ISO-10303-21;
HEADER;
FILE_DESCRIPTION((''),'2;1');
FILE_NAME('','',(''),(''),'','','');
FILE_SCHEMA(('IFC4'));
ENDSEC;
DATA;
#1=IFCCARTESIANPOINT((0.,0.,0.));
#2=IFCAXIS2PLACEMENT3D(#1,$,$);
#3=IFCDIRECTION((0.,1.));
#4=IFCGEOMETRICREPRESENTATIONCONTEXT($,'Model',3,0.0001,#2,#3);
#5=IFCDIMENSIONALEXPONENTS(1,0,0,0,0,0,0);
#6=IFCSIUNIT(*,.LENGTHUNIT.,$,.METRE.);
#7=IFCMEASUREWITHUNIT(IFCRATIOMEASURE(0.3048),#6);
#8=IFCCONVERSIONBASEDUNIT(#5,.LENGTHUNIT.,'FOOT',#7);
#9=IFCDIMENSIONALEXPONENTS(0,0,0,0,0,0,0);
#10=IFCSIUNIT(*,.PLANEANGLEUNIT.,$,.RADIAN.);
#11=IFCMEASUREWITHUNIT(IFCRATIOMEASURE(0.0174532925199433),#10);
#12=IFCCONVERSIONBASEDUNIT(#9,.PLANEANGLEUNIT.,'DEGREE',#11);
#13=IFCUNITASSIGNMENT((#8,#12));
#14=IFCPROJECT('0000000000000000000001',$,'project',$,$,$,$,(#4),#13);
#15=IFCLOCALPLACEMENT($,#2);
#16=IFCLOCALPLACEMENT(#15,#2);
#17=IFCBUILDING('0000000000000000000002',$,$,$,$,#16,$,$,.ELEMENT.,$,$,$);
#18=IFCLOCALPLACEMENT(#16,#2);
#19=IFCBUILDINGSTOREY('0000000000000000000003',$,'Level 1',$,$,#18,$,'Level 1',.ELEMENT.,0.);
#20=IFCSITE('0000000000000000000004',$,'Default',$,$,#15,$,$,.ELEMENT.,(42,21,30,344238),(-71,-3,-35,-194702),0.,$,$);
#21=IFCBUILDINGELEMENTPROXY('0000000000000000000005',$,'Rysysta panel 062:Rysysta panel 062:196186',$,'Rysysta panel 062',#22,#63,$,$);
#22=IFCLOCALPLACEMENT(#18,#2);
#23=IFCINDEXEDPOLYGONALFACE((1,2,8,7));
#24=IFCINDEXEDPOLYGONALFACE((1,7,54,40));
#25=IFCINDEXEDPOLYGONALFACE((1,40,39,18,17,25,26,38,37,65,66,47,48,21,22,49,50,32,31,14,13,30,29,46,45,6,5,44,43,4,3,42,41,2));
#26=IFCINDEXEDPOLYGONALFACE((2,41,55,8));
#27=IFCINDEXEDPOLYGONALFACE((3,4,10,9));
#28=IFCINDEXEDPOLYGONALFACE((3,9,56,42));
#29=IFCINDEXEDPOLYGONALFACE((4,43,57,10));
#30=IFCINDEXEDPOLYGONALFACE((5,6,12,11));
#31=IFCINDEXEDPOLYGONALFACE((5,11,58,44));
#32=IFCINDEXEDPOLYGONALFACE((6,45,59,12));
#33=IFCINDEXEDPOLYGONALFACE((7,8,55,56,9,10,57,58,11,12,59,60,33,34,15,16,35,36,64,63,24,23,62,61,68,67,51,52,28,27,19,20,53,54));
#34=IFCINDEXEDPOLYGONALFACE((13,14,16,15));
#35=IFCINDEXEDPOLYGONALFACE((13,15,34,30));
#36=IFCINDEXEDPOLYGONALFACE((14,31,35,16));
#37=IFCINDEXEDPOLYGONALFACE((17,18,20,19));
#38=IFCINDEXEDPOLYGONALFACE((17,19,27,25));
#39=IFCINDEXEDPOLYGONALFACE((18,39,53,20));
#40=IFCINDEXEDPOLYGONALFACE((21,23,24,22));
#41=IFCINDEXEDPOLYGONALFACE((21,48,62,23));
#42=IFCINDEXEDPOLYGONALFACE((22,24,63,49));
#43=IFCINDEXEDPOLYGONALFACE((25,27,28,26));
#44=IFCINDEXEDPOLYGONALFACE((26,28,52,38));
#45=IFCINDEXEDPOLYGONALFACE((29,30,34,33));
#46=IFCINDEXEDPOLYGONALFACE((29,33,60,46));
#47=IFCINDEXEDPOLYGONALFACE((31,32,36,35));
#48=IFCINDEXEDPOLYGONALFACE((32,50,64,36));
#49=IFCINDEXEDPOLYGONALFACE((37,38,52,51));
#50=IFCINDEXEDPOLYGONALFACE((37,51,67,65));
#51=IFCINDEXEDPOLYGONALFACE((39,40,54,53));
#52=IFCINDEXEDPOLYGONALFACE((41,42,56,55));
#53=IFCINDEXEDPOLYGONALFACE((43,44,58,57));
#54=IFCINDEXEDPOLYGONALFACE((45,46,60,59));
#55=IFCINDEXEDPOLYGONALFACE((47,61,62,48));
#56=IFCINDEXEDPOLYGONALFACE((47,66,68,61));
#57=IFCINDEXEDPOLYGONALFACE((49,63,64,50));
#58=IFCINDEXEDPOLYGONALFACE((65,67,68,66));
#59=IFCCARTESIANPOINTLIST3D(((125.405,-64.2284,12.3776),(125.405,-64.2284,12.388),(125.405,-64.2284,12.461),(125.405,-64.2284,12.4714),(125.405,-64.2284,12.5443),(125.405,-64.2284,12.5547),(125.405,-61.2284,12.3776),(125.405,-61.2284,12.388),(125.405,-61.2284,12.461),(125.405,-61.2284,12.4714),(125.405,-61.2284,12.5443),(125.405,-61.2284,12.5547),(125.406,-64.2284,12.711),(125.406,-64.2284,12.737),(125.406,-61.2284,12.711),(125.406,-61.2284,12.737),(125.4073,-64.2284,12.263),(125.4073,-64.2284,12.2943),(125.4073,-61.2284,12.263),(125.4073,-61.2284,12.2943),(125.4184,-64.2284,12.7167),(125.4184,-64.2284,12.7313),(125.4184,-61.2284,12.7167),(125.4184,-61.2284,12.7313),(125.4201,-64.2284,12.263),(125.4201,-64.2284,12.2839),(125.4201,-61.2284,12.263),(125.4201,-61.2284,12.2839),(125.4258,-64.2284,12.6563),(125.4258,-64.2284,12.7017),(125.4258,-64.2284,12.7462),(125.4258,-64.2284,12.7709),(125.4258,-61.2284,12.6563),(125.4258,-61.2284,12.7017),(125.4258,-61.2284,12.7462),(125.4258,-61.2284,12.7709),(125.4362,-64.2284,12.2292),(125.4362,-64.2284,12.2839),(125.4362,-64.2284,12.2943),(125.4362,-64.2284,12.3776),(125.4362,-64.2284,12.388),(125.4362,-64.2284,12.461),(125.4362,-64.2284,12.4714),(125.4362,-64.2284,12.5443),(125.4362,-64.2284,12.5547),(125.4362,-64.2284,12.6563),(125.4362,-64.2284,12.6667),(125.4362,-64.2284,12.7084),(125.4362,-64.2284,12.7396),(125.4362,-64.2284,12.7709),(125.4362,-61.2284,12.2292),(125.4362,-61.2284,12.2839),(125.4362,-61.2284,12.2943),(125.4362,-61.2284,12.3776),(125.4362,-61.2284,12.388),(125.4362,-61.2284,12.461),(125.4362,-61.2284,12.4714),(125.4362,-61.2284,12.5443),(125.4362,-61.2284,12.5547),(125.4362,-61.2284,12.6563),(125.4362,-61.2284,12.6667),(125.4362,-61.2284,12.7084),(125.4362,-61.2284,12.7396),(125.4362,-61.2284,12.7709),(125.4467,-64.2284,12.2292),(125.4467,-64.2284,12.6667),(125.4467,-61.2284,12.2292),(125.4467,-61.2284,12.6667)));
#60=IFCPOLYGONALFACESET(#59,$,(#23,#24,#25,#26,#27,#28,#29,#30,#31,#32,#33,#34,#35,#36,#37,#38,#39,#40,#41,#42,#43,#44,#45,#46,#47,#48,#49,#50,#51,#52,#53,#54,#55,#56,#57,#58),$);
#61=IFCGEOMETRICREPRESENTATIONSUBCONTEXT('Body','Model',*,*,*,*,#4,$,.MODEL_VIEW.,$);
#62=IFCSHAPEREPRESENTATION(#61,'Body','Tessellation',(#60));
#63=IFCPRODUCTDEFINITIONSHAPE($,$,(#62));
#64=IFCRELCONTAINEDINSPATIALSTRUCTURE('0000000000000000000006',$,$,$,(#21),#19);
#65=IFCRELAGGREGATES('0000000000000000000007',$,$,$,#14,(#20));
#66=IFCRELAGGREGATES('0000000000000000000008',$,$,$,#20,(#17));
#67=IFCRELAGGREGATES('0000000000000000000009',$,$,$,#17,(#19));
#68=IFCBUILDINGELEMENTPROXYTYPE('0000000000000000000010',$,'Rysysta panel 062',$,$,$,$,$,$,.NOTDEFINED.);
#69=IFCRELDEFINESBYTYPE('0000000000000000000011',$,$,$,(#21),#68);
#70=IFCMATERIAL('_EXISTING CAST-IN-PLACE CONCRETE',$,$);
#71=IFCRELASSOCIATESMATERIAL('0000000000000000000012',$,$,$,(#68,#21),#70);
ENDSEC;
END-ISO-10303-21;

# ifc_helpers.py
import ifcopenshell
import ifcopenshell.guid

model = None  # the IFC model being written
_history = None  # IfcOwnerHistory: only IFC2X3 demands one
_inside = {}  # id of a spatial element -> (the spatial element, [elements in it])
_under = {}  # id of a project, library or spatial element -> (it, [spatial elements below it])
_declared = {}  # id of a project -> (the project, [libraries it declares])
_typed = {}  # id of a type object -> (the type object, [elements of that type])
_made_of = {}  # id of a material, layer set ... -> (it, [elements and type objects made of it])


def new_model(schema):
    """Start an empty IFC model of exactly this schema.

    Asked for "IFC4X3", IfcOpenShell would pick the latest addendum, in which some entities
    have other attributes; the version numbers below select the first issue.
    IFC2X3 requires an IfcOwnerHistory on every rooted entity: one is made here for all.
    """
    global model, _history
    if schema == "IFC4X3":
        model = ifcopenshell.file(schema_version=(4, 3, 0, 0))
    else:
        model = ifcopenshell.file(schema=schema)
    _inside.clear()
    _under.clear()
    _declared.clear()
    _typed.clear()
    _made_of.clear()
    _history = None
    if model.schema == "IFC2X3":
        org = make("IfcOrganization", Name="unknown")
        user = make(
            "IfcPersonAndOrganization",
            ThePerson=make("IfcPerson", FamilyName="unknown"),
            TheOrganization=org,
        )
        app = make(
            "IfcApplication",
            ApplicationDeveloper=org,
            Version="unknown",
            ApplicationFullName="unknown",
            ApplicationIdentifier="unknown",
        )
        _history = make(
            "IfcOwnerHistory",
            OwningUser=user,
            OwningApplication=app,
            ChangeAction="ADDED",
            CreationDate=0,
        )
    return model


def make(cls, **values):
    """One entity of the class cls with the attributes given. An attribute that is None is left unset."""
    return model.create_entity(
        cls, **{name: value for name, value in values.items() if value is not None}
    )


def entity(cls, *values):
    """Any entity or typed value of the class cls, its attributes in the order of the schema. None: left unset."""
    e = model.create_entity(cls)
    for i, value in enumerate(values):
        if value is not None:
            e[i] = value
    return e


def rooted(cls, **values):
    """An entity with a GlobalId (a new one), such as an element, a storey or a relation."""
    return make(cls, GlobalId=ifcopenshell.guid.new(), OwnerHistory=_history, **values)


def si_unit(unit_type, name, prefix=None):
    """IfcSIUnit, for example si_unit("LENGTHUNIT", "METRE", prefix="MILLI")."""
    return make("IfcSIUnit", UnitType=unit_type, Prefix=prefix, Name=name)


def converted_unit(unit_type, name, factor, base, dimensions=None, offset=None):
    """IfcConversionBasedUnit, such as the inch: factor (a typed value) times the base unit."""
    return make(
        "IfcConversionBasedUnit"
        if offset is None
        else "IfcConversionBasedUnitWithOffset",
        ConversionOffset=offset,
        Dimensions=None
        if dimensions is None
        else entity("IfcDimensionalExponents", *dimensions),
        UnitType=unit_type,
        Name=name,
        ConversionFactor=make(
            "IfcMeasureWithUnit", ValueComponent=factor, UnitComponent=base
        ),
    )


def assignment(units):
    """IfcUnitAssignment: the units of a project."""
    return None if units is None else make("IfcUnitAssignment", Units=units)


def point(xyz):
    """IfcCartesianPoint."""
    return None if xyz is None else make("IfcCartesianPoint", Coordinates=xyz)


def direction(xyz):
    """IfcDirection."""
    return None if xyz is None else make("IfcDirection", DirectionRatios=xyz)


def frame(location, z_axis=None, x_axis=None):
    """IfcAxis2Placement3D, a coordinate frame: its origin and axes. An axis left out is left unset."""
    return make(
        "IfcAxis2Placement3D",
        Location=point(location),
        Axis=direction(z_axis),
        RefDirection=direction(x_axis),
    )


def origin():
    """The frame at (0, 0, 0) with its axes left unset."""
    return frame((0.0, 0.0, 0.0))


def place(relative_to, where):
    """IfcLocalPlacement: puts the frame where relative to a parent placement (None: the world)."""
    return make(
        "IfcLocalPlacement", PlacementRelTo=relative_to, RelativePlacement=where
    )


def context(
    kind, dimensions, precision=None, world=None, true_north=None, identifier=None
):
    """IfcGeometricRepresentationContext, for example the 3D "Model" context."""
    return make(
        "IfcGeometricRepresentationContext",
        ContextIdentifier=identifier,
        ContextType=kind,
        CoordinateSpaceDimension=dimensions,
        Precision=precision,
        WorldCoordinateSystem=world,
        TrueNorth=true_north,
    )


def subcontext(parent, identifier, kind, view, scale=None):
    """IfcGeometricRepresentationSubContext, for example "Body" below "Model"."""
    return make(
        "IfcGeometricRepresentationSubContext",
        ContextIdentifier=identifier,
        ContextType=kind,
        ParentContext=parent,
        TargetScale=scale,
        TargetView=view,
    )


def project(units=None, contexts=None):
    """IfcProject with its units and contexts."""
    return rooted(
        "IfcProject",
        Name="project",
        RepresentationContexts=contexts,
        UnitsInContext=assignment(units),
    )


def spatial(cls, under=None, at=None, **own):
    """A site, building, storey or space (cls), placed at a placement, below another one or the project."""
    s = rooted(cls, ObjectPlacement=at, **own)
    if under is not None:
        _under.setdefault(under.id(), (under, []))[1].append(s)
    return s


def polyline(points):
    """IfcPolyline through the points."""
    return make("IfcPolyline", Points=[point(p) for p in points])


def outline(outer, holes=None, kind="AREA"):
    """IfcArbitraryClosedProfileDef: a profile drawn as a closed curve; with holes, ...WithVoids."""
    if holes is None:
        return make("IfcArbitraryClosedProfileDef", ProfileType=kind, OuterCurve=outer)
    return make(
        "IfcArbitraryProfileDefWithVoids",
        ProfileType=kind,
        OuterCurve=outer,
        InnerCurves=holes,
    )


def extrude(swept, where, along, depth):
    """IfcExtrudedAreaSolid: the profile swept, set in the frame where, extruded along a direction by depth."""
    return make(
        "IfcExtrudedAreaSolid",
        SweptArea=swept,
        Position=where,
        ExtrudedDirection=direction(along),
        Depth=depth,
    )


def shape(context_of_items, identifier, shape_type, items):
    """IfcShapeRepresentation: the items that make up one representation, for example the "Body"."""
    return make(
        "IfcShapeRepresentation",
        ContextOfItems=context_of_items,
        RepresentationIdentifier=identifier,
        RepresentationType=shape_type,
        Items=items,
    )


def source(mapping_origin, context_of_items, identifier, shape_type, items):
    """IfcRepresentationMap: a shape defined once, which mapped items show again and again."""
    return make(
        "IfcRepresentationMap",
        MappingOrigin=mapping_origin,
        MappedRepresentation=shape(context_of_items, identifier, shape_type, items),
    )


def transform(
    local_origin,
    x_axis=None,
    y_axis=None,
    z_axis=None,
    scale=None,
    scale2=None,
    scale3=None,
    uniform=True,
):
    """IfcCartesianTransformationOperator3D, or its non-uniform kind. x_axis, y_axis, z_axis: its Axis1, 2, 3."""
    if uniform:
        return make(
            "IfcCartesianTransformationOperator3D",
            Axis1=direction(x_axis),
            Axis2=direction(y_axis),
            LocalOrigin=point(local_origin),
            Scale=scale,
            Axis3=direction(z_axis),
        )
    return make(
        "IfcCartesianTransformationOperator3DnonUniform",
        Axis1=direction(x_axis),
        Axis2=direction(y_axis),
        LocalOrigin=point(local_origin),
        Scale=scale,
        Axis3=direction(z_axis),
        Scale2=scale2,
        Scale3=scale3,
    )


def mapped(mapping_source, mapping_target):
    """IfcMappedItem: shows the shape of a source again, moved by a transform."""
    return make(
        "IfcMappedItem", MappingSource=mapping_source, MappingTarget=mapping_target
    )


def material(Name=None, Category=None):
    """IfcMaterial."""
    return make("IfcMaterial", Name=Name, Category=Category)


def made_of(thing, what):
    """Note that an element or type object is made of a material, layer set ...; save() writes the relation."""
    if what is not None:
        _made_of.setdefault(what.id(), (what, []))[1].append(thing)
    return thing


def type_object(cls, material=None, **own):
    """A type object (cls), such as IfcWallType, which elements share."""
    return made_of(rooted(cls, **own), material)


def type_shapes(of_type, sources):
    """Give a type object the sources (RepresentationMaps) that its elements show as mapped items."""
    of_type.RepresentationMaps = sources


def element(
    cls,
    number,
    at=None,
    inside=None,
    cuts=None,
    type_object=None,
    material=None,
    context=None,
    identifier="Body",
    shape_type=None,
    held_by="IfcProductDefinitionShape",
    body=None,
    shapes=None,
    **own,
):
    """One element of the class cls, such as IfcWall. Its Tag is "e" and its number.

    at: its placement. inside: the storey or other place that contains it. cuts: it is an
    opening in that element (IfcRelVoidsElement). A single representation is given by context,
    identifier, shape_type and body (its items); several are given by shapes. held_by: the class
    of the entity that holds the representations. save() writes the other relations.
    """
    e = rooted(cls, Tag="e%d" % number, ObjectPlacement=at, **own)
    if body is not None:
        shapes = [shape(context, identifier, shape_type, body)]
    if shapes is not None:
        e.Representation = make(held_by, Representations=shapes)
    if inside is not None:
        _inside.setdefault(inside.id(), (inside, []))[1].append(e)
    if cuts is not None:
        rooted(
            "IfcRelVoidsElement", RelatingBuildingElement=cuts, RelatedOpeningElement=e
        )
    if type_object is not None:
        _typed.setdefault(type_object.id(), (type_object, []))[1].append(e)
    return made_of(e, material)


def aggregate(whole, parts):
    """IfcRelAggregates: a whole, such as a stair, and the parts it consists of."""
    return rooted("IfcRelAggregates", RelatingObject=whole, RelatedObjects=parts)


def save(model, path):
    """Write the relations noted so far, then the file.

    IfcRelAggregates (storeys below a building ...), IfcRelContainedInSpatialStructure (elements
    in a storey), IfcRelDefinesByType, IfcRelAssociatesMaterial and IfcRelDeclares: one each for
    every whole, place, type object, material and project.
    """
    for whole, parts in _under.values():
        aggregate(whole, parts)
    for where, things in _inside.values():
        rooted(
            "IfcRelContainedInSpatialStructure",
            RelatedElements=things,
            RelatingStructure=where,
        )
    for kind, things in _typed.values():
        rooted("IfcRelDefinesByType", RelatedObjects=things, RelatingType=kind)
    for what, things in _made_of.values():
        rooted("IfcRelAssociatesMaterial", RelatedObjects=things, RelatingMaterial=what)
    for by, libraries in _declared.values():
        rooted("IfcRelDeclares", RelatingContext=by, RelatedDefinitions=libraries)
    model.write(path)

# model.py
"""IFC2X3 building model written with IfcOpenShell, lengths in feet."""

from ifc_helpers import new_model, entity, si_unit, converted_unit, direction, frame, origin, place, context, subcontext, project, spatial, polyline, outline, extrude, source, transform, mapped, material, type_object, type_shapes, element, save


model = new_model("IFC2X3")

# Units and contexts
model_context = context("Model", 3, precision=0.0001, world=origin(), true_north=direction((0.0, 1.0)))
body_context = subcontext(model_context, "Body", "Model", "MODEL_VIEW")
ifc_project = project(units=[converted_unit("LENGTHUNIT", "FOOT", entity("IfcRatioMeasure", 0.3048), si_unit("LENGTHUNIT", "METRE"), dimensions=[1, 0, 0, 0, 0, 0, 0]), converted_unit("PLANEANGLEUNIT", "DEGREE", entity("IfcRatioMeasure", 0.0174532925199433), si_unit("PLANEANGLEUNIT", "RADIAN"), dimensions=[0, 0, 0, 0, 0, 0, 0])], contexts=[model_context])

# Site, building, storey
site_placement = place(None, origin())
site = spatial("IfcSite", under=ifc_project, at=site_placement, Name="Default", CompositionType="ELEMENT", RefLatitude=(42, 21, 30, 344238), RefLongitude=(-71, -3, -35, -194702), RefElevation=0.0)
building_placement = place(site_placement, origin())
building = spatial("IfcBuilding", under=site, at=building_placement, CompositionType="ELEMENT")
storey_placement = place(building_placement, origin())
storey = spatial("IfcBuildingStorey", under=building, at=storey_placement, Name="Level 1", LongName="Level 1", CompositionType="ELEMENT", Elevation=0.0)

# Building element proxy
ifc_material_1 = material(Name="_EXISTING CAST-IN-PLACE CONCRETE")
building_element_proxy_type_1 = type_object("IfcBuildingElementProxyType", Name="Rysysta panel 062", PredefinedType="NOTDEFINED", material=ifc_material_1)
shared_shape_1 = source(origin(), body_context, "Body", "SweptSolid", [
    extrude(outline(polyline([(-0.1457, -0.022), (0.2918, -0.022), (0.2918, -0.0116), (0.2371, -0.0116), (0.2371, 0.0045), (0.258, 0.0045), (0.258, 0.0173), (0.2267, 0.0173), (0.2267, -0.0116), (0.1434, -0.0116), (0.1434, 0.0196), (0.133, 0.0196), (0.133, -0.0116), (0.06, -0.0116), (0.06, 0.0196), (0.0496, 0.0196), (0.0496, -0.0116), (-0.0233, -0.0116), (-0.0233, 0.0196), (-0.0337, 0.0196), (-0.0337, -0.0116), (-0.1353, -0.0116), (-0.1353, -0.0012), (-0.1807, -0.0012), (-0.1899, 0.0186), (-0.216, 0.0186), (-0.2252, -0.0012), (-0.2498, -0.0012), (-0.2498, -0.0116), (-0.2186, -0.0116), (-0.2103, 0.0062), (-0.1956, 0.0062), (-0.1873, -0.0116), (-0.1457, -0.0116), (-0.1457, -0.022)])), frame((125.4246, -64.2284, 12.521), z_axis=(0.0, 1.0, 0.0), x_axis=(0.0, 0.0, -1.0)), (0.0, 0.0, 1.0), 3.0),
])
type_shapes(building_element_proxy_type_1, [shared_shape_1])
proxy_1_placement = place(storey_placement, origin())
element("IfcBuildingElementProxy", 1, at=proxy_1_placement, inside=storey, type_object=building_element_proxy_type_1, material=ifc_material_1, Name="Rysysta panel 062:Rysysta panel 062:196186", ObjectType="Rysysta panel 062", context=body_context, shape_type="MappedRepresentation", body=[
    mapped(shared_shape_1, transform((0.0, 0.0, 0.0), scale=1.0)),
])

save(model, "model.ifc")
